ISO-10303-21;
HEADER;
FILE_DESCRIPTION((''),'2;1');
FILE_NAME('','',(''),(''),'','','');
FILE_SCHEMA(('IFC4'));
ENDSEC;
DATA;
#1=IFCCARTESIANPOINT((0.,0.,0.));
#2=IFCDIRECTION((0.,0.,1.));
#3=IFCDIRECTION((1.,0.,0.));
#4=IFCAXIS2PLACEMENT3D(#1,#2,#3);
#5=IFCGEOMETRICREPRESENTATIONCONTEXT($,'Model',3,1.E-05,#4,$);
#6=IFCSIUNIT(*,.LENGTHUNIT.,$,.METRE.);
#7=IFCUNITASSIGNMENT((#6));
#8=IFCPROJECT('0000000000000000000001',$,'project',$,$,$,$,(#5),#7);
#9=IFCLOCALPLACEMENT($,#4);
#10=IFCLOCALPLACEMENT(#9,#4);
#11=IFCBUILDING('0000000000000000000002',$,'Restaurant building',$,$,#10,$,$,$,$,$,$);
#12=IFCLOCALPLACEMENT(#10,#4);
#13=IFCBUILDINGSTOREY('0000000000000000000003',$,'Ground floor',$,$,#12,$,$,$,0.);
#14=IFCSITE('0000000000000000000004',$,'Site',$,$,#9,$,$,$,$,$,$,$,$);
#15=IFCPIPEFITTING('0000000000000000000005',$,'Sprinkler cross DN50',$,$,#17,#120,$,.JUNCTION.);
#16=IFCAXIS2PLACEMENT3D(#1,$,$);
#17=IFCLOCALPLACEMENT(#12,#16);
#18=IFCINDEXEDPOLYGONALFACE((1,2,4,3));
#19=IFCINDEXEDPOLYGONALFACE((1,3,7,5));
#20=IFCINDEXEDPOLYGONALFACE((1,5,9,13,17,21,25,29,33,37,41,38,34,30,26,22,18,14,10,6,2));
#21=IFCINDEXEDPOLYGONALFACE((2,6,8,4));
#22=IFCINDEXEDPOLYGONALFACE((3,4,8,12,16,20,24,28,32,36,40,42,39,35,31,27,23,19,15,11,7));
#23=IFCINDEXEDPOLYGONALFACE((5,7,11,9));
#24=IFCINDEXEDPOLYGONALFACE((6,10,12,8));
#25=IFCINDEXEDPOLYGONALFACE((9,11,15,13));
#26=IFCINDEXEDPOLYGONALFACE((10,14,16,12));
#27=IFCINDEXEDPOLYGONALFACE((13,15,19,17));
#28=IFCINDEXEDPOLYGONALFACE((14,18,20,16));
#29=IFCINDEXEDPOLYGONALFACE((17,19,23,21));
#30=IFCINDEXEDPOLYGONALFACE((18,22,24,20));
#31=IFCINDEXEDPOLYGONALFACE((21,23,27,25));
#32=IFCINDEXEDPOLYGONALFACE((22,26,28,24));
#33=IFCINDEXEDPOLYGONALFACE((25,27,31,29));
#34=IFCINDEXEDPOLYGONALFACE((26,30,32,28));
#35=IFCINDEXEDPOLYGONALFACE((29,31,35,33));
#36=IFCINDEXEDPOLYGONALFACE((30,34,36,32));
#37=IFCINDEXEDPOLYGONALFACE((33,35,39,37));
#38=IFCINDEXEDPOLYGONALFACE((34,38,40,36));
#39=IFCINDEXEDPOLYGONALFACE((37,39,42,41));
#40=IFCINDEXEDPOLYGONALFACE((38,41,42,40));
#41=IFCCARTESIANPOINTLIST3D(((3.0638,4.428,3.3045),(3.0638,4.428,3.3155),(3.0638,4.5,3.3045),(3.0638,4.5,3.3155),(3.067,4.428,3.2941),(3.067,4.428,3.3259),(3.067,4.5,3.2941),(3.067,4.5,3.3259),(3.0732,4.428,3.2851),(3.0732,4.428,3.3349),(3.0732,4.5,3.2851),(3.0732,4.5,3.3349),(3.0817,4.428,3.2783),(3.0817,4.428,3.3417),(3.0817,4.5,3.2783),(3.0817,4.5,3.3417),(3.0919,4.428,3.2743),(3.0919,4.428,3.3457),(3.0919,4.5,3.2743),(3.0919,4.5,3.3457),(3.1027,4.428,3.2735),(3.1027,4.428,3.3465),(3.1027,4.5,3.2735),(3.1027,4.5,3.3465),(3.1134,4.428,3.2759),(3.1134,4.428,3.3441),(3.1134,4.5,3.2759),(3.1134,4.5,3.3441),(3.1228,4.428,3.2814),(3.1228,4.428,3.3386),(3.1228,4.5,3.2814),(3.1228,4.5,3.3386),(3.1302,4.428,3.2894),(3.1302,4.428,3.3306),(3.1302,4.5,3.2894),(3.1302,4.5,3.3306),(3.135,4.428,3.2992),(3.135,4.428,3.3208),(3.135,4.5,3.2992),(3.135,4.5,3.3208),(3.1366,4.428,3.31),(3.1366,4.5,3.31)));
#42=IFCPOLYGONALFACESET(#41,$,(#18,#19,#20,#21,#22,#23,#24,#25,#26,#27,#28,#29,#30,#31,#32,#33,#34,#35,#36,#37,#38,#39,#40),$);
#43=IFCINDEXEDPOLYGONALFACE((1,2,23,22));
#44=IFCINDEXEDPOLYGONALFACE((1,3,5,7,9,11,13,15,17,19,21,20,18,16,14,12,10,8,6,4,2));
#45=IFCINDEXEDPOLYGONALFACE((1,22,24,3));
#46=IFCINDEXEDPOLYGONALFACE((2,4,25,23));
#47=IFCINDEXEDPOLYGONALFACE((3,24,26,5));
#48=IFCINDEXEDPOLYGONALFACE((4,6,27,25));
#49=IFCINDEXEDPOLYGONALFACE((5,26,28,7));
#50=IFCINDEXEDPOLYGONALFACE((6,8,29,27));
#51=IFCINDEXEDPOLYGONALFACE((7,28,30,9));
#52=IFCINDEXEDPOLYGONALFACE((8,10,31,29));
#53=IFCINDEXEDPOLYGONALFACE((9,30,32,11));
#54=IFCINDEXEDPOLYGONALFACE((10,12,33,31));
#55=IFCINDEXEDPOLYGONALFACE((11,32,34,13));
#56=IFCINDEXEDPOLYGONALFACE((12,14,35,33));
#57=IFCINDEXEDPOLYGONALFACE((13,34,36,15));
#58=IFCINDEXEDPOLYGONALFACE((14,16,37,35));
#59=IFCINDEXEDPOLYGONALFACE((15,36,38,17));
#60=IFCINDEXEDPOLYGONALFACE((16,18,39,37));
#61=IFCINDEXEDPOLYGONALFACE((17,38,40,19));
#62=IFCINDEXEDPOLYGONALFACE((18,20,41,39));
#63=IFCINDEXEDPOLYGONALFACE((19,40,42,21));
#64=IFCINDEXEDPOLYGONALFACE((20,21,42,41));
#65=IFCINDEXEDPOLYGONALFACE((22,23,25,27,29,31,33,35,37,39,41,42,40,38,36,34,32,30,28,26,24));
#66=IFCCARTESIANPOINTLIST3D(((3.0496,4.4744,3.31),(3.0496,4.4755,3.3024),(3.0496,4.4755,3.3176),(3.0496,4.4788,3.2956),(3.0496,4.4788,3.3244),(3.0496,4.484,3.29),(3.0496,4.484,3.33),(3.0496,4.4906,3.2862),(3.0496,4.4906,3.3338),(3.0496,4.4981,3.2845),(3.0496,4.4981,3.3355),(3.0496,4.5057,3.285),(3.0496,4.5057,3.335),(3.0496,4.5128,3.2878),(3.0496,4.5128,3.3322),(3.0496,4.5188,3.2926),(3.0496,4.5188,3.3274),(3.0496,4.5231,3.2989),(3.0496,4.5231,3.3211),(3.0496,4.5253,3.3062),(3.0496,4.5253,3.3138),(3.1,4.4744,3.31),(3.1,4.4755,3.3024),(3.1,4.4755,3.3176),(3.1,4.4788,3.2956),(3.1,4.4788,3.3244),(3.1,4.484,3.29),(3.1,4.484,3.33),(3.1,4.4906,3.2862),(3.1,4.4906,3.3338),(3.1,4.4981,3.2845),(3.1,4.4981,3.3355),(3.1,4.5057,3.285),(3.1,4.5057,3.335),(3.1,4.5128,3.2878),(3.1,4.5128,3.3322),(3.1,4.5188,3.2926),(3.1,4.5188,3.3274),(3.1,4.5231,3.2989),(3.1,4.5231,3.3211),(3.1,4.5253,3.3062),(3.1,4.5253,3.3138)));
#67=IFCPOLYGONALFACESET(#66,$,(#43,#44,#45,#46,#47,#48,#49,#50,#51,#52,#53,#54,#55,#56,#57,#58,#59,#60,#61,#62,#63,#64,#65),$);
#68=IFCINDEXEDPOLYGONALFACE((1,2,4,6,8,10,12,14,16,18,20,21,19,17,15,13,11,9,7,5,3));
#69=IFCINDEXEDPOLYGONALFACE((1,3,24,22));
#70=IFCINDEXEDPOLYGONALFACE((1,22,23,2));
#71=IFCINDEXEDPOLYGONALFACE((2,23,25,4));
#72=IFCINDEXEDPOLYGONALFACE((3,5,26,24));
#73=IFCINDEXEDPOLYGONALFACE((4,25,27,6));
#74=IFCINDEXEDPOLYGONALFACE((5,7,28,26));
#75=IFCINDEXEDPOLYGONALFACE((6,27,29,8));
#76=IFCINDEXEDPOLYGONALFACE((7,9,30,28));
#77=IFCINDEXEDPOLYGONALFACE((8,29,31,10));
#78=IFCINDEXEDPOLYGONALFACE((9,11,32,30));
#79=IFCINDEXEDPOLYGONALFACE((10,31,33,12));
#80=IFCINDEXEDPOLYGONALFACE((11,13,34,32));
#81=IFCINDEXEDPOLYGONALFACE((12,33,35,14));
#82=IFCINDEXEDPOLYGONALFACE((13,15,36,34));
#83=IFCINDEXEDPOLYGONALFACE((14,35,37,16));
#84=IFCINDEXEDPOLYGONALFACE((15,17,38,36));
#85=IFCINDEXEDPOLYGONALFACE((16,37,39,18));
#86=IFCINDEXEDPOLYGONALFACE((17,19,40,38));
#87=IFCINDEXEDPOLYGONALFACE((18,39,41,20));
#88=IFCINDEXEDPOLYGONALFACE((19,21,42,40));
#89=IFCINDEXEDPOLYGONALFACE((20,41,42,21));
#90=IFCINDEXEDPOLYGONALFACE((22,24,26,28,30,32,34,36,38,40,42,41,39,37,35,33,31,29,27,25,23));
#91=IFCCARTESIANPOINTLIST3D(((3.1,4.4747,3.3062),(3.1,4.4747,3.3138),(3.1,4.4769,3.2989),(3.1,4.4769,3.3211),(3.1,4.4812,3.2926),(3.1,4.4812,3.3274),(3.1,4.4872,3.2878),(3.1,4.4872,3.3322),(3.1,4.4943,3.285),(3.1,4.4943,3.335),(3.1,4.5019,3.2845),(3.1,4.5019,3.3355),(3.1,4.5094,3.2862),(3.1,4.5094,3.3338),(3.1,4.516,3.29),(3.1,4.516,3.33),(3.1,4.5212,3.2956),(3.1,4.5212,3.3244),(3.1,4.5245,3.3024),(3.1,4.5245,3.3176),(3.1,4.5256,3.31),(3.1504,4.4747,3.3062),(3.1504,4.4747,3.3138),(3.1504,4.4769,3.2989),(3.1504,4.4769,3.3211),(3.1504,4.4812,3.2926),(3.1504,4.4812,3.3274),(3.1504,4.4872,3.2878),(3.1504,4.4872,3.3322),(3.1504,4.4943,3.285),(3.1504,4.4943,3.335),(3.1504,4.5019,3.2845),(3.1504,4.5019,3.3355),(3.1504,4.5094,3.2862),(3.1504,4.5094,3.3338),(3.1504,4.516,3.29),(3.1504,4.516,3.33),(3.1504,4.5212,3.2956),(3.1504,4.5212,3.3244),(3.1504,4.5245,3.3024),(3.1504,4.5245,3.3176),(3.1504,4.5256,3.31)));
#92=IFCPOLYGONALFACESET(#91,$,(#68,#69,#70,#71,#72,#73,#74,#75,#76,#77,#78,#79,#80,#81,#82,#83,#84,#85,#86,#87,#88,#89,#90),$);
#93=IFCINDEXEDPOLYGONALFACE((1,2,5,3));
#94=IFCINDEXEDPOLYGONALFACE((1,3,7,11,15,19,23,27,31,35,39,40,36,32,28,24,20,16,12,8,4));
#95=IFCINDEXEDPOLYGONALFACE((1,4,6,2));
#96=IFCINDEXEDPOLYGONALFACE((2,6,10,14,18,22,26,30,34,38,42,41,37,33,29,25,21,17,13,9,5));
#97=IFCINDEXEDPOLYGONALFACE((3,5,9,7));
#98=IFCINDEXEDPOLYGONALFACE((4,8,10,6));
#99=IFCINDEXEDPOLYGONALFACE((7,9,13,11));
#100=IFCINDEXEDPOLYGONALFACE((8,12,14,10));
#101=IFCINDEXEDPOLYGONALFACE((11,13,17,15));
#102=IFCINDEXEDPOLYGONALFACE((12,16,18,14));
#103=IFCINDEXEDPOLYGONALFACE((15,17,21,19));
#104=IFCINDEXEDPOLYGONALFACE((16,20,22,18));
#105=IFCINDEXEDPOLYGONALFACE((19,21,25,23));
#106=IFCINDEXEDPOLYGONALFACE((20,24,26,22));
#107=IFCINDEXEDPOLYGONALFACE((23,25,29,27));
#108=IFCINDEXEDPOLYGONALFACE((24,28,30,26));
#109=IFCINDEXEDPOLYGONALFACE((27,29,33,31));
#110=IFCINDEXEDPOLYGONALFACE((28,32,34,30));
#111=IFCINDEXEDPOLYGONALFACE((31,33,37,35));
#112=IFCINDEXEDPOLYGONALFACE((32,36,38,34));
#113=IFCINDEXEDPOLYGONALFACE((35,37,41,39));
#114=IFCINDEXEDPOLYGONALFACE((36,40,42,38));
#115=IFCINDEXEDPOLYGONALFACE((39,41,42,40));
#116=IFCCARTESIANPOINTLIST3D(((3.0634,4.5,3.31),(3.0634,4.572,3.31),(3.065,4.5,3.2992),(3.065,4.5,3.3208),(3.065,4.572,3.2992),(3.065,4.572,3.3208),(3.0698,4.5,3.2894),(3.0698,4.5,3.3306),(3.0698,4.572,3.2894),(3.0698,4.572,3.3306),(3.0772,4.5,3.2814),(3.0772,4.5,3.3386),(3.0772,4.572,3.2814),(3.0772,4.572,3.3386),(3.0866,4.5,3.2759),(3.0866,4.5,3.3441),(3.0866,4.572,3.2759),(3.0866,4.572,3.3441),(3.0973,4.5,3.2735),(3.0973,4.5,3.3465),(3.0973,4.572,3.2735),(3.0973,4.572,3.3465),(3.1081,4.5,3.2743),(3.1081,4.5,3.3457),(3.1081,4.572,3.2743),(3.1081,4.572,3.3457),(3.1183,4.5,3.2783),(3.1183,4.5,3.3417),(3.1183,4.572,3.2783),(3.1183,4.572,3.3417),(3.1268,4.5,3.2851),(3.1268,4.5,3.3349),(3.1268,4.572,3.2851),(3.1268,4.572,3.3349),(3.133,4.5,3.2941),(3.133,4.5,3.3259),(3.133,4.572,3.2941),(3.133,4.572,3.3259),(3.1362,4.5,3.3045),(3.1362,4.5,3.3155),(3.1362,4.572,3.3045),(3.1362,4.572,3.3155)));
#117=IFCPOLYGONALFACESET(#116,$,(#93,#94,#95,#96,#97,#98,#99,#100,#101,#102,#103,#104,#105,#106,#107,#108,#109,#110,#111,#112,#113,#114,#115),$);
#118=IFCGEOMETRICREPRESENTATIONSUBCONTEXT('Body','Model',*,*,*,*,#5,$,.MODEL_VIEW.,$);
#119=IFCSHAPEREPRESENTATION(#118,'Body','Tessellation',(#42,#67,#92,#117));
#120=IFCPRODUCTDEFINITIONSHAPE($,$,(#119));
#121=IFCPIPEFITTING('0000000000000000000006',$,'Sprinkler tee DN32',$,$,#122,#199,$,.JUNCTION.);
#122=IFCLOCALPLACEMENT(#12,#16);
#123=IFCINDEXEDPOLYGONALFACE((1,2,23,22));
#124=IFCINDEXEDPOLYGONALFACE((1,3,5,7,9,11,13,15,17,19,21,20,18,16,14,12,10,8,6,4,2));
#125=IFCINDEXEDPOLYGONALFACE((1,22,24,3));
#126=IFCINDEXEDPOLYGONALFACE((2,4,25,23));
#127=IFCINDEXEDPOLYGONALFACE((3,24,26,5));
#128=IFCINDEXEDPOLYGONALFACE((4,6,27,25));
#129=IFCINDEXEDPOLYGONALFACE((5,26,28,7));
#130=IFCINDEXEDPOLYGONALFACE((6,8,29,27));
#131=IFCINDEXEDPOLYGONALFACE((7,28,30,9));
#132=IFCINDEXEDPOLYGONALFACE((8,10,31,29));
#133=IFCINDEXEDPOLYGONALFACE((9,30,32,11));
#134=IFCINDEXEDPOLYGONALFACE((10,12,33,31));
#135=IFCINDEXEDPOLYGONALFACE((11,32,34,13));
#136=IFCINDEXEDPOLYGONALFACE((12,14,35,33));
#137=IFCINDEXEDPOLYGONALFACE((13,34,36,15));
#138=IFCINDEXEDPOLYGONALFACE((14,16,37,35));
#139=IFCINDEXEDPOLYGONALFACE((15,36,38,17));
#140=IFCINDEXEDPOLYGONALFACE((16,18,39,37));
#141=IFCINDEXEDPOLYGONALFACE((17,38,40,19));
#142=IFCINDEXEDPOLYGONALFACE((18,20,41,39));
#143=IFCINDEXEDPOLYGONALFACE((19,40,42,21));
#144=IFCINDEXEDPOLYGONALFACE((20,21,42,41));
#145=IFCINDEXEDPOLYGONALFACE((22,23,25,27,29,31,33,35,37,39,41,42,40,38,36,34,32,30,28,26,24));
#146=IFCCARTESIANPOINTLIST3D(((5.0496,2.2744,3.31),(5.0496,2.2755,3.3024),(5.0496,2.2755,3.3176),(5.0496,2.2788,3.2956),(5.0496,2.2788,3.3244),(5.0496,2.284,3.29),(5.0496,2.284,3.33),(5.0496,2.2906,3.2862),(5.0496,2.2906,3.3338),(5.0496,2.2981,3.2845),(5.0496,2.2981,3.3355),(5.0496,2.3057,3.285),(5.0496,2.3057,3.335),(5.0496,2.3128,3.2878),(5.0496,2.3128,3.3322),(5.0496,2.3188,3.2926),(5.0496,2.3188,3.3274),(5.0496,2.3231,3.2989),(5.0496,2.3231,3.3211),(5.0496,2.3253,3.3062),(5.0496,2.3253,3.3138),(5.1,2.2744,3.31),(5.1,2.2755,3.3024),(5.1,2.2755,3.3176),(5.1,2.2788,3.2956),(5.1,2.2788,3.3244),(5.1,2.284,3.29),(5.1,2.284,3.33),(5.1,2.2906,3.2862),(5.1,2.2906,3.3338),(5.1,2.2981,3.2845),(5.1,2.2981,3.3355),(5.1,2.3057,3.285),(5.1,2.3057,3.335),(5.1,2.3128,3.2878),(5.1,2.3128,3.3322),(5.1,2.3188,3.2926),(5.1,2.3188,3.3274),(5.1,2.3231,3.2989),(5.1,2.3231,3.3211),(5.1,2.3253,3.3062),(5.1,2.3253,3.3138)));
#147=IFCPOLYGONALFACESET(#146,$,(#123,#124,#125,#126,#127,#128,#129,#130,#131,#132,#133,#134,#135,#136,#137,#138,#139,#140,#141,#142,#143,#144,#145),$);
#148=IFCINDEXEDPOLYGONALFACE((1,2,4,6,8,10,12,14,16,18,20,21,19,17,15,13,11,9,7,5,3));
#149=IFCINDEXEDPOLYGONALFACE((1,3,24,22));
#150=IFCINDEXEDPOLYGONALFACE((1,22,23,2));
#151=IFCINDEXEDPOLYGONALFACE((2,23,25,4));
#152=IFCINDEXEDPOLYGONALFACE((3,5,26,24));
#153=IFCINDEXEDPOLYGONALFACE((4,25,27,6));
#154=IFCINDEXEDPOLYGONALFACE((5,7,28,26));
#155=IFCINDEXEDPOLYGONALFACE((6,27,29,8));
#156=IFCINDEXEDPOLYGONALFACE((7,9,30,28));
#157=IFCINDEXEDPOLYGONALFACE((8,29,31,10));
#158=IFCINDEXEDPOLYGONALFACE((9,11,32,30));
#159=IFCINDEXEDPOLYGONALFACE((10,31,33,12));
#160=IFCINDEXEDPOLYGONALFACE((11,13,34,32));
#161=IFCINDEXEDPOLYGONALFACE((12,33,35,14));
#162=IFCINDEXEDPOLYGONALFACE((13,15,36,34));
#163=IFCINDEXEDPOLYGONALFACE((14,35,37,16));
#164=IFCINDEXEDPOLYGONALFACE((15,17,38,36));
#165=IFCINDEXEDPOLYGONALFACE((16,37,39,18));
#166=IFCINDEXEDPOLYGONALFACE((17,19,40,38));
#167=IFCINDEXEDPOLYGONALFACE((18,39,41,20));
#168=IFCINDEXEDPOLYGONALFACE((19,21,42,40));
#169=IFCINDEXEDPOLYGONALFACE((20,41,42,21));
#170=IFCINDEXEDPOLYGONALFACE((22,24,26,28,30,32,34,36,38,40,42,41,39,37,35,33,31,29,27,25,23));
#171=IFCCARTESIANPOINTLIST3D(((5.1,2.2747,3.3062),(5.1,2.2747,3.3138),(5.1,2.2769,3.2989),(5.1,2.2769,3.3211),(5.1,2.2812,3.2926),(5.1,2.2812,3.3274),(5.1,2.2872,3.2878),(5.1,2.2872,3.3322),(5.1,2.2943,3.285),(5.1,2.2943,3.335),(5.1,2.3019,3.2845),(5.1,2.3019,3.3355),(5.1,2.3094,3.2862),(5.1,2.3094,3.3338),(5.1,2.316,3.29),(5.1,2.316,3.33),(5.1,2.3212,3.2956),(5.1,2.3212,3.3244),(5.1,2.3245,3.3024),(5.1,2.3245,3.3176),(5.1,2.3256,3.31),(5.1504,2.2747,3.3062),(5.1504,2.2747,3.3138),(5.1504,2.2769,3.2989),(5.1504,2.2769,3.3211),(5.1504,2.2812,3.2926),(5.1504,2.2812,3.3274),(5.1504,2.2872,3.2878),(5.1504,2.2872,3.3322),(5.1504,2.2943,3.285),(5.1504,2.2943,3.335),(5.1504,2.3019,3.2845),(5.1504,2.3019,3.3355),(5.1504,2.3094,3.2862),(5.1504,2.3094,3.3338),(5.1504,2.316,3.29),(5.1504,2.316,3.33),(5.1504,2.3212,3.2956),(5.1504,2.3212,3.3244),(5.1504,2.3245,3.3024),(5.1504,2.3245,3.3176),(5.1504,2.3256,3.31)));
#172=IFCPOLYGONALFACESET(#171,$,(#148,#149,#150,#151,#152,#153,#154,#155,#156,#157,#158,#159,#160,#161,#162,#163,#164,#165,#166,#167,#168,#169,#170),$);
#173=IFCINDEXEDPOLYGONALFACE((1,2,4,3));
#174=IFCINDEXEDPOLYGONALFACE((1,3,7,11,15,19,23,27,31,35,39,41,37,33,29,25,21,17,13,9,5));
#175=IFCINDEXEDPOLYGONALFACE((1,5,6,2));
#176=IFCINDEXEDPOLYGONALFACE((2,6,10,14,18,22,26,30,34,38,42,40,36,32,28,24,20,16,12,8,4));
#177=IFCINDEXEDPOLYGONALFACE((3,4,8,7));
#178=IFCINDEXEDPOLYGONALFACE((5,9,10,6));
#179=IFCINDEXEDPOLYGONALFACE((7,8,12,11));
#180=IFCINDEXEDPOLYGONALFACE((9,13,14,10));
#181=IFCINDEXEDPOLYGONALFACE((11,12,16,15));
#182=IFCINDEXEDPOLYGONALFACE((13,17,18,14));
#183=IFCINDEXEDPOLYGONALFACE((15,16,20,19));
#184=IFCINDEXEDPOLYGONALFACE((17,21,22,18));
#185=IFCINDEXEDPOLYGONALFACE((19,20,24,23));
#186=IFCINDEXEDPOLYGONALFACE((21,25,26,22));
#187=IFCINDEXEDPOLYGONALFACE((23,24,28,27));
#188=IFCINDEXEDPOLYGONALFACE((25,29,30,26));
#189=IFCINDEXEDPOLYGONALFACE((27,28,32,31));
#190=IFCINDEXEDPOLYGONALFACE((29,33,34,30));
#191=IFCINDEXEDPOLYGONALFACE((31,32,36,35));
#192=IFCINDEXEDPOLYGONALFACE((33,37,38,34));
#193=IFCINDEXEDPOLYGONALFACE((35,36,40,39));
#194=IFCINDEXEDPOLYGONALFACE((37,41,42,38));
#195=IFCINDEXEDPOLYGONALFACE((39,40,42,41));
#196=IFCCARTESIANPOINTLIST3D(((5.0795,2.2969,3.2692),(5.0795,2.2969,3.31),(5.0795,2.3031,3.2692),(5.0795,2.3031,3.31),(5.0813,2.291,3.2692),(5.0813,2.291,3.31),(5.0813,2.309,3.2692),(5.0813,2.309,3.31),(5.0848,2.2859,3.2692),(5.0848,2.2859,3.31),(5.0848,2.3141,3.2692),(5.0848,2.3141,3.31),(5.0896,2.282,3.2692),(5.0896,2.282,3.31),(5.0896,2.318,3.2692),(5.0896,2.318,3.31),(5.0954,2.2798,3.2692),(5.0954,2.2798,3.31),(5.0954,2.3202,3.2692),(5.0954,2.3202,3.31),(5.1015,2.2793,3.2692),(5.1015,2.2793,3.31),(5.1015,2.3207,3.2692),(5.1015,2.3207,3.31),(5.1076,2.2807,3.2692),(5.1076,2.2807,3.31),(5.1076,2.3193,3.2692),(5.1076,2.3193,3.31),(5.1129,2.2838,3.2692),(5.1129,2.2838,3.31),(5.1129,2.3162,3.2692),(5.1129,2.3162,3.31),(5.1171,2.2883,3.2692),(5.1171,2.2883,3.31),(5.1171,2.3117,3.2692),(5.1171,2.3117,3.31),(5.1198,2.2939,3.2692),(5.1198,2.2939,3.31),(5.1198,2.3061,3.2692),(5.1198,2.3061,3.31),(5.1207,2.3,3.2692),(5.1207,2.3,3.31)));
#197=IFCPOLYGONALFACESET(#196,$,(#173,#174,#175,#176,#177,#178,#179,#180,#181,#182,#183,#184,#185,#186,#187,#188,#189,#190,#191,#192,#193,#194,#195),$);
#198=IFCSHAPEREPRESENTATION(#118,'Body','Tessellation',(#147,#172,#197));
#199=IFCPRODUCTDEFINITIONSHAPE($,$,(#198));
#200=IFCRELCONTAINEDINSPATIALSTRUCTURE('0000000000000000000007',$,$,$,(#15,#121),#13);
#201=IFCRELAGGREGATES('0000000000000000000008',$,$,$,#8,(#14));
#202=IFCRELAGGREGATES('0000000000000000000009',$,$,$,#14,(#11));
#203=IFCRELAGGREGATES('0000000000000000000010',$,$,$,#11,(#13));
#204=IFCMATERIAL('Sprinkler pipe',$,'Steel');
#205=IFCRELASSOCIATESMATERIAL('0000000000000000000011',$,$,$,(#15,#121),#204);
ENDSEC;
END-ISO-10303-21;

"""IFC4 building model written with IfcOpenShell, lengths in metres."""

from ifc_helpers import new_model, si_unit, frame, origin_with_axes, origin_2d, place, context, subcontext, project, spatial, circle, extrude, material, element, save


model = new_model("IFC4")

# Units and contexts
model_context = context("Model", 3, precision=1e-05, world=origin_with_axes())
body_context = subcontext(model_context, "Body", "Model", "MODEL_VIEW")
ifc_project = project(units=[si_unit("LENGTHUNIT", "METRE")], contexts=[model_context])

# Site, building, storey
site_placement = place(None, origin_with_axes())
site = spatial("IfcSite", under=ifc_project, at=site_placement, Name="Site")
building_placement = place(site_placement, origin_with_axes())
building = spatial("IfcBuilding", under=site, at=building_placement, Name="Restaurant building")
storey_placement = place(building_placement, origin_with_axes())
storey = spatial("IfcBuildingStorey", under=building, at=storey_placement, Name="Ground floor", Elevation=0.0)

# Shared definitions
ifc_material_1 = material(Name="Sprinkler pipe", Category="Steel")

# Pipe fittings
pipe_fitting_1_placement = place(storey_placement, frame((3.1, 4.5, 3.31)))
element("IfcPipeFitting", 1, at=pipe_fitting_1_placement, inside=storey, material=ifc_material_1, Name="Sprinkler cross DN50", PredefinedType="JUNCTION", context=body_context, shape_type="SweptSolid", body=[
    extrude(circle(Radius=0.0366, at=origin_2d()), frame((0.0, 0.0, 0.0), z_axis=(0.0, -1.0, 0.0), x_axis=(1.0, 0.0, 0.0)), (0.0, 0.0, 1.0), 0.072),
    extrude(circle(Radius=0.0256, at=origin_2d()), frame((0.0, 0.0, 0.0), z_axis=(-1.0, 0.0, 0.0), x_axis=(0.0, -1.0, 0.0)), (0.0, 0.0, 1.0), 0.0504),
    extrude(circle(Radius=0.0256, at=origin_2d()), frame((0.0, 0.0, 0.0), z_axis=(1.0, 0.0, 0.0), x_axis=(0.0, 1.0, 0.0)), (0.0, 0.0, 1.0), 0.0504),
    extrude(circle(Radius=0.0366, at=origin_2d()), frame((0.0, 0.0, 0.0), z_axis=(0.0, 1.0, 0.0), x_axis=(-1.0, 0.0, 0.0)), (0.0, 0.0, 1.0), 0.072),
])
pipe_fitting_2_placement = place(storey_placement, frame((5.1, 2.3, 3.31)))
element("IfcPipeFitting", 2, at=pipe_fitting_2_placement, inside=storey, material=ifc_material_1, Name="Sprinkler tee DN32", PredefinedType="JUNCTION", context=body_context, shape_type="SweptSolid", body=[
    extrude(circle(Radius=0.0256, at=origin_2d()), frame((0.0, 0.0, 0.0), z_axis=(-1.0, 0.0, 0.0), x_axis=(0.0, -1.0, 0.0)), (0.0, 0.0, 1.0), 0.0504),
    extrude(circle(Radius=0.0256, at=origin_2d()), frame((0.0, 0.0, 0.0), z_axis=(1.0, 0.0, 0.0), x_axis=(0.0, 1.0, 0.0)), (0.0, 0.0, 1.0), 0.0504),
    extrude(circle(Radius=0.0207, at=origin_2d()), frame((0.0, 0.0, 0.0), z_axis=(0.0, 0.0, -1.0), x_axis=(1.0, 0.0, 0.0)), (0.0, 0.0, 1.0), 0.0408),
])

save(model, "model.ifc")
